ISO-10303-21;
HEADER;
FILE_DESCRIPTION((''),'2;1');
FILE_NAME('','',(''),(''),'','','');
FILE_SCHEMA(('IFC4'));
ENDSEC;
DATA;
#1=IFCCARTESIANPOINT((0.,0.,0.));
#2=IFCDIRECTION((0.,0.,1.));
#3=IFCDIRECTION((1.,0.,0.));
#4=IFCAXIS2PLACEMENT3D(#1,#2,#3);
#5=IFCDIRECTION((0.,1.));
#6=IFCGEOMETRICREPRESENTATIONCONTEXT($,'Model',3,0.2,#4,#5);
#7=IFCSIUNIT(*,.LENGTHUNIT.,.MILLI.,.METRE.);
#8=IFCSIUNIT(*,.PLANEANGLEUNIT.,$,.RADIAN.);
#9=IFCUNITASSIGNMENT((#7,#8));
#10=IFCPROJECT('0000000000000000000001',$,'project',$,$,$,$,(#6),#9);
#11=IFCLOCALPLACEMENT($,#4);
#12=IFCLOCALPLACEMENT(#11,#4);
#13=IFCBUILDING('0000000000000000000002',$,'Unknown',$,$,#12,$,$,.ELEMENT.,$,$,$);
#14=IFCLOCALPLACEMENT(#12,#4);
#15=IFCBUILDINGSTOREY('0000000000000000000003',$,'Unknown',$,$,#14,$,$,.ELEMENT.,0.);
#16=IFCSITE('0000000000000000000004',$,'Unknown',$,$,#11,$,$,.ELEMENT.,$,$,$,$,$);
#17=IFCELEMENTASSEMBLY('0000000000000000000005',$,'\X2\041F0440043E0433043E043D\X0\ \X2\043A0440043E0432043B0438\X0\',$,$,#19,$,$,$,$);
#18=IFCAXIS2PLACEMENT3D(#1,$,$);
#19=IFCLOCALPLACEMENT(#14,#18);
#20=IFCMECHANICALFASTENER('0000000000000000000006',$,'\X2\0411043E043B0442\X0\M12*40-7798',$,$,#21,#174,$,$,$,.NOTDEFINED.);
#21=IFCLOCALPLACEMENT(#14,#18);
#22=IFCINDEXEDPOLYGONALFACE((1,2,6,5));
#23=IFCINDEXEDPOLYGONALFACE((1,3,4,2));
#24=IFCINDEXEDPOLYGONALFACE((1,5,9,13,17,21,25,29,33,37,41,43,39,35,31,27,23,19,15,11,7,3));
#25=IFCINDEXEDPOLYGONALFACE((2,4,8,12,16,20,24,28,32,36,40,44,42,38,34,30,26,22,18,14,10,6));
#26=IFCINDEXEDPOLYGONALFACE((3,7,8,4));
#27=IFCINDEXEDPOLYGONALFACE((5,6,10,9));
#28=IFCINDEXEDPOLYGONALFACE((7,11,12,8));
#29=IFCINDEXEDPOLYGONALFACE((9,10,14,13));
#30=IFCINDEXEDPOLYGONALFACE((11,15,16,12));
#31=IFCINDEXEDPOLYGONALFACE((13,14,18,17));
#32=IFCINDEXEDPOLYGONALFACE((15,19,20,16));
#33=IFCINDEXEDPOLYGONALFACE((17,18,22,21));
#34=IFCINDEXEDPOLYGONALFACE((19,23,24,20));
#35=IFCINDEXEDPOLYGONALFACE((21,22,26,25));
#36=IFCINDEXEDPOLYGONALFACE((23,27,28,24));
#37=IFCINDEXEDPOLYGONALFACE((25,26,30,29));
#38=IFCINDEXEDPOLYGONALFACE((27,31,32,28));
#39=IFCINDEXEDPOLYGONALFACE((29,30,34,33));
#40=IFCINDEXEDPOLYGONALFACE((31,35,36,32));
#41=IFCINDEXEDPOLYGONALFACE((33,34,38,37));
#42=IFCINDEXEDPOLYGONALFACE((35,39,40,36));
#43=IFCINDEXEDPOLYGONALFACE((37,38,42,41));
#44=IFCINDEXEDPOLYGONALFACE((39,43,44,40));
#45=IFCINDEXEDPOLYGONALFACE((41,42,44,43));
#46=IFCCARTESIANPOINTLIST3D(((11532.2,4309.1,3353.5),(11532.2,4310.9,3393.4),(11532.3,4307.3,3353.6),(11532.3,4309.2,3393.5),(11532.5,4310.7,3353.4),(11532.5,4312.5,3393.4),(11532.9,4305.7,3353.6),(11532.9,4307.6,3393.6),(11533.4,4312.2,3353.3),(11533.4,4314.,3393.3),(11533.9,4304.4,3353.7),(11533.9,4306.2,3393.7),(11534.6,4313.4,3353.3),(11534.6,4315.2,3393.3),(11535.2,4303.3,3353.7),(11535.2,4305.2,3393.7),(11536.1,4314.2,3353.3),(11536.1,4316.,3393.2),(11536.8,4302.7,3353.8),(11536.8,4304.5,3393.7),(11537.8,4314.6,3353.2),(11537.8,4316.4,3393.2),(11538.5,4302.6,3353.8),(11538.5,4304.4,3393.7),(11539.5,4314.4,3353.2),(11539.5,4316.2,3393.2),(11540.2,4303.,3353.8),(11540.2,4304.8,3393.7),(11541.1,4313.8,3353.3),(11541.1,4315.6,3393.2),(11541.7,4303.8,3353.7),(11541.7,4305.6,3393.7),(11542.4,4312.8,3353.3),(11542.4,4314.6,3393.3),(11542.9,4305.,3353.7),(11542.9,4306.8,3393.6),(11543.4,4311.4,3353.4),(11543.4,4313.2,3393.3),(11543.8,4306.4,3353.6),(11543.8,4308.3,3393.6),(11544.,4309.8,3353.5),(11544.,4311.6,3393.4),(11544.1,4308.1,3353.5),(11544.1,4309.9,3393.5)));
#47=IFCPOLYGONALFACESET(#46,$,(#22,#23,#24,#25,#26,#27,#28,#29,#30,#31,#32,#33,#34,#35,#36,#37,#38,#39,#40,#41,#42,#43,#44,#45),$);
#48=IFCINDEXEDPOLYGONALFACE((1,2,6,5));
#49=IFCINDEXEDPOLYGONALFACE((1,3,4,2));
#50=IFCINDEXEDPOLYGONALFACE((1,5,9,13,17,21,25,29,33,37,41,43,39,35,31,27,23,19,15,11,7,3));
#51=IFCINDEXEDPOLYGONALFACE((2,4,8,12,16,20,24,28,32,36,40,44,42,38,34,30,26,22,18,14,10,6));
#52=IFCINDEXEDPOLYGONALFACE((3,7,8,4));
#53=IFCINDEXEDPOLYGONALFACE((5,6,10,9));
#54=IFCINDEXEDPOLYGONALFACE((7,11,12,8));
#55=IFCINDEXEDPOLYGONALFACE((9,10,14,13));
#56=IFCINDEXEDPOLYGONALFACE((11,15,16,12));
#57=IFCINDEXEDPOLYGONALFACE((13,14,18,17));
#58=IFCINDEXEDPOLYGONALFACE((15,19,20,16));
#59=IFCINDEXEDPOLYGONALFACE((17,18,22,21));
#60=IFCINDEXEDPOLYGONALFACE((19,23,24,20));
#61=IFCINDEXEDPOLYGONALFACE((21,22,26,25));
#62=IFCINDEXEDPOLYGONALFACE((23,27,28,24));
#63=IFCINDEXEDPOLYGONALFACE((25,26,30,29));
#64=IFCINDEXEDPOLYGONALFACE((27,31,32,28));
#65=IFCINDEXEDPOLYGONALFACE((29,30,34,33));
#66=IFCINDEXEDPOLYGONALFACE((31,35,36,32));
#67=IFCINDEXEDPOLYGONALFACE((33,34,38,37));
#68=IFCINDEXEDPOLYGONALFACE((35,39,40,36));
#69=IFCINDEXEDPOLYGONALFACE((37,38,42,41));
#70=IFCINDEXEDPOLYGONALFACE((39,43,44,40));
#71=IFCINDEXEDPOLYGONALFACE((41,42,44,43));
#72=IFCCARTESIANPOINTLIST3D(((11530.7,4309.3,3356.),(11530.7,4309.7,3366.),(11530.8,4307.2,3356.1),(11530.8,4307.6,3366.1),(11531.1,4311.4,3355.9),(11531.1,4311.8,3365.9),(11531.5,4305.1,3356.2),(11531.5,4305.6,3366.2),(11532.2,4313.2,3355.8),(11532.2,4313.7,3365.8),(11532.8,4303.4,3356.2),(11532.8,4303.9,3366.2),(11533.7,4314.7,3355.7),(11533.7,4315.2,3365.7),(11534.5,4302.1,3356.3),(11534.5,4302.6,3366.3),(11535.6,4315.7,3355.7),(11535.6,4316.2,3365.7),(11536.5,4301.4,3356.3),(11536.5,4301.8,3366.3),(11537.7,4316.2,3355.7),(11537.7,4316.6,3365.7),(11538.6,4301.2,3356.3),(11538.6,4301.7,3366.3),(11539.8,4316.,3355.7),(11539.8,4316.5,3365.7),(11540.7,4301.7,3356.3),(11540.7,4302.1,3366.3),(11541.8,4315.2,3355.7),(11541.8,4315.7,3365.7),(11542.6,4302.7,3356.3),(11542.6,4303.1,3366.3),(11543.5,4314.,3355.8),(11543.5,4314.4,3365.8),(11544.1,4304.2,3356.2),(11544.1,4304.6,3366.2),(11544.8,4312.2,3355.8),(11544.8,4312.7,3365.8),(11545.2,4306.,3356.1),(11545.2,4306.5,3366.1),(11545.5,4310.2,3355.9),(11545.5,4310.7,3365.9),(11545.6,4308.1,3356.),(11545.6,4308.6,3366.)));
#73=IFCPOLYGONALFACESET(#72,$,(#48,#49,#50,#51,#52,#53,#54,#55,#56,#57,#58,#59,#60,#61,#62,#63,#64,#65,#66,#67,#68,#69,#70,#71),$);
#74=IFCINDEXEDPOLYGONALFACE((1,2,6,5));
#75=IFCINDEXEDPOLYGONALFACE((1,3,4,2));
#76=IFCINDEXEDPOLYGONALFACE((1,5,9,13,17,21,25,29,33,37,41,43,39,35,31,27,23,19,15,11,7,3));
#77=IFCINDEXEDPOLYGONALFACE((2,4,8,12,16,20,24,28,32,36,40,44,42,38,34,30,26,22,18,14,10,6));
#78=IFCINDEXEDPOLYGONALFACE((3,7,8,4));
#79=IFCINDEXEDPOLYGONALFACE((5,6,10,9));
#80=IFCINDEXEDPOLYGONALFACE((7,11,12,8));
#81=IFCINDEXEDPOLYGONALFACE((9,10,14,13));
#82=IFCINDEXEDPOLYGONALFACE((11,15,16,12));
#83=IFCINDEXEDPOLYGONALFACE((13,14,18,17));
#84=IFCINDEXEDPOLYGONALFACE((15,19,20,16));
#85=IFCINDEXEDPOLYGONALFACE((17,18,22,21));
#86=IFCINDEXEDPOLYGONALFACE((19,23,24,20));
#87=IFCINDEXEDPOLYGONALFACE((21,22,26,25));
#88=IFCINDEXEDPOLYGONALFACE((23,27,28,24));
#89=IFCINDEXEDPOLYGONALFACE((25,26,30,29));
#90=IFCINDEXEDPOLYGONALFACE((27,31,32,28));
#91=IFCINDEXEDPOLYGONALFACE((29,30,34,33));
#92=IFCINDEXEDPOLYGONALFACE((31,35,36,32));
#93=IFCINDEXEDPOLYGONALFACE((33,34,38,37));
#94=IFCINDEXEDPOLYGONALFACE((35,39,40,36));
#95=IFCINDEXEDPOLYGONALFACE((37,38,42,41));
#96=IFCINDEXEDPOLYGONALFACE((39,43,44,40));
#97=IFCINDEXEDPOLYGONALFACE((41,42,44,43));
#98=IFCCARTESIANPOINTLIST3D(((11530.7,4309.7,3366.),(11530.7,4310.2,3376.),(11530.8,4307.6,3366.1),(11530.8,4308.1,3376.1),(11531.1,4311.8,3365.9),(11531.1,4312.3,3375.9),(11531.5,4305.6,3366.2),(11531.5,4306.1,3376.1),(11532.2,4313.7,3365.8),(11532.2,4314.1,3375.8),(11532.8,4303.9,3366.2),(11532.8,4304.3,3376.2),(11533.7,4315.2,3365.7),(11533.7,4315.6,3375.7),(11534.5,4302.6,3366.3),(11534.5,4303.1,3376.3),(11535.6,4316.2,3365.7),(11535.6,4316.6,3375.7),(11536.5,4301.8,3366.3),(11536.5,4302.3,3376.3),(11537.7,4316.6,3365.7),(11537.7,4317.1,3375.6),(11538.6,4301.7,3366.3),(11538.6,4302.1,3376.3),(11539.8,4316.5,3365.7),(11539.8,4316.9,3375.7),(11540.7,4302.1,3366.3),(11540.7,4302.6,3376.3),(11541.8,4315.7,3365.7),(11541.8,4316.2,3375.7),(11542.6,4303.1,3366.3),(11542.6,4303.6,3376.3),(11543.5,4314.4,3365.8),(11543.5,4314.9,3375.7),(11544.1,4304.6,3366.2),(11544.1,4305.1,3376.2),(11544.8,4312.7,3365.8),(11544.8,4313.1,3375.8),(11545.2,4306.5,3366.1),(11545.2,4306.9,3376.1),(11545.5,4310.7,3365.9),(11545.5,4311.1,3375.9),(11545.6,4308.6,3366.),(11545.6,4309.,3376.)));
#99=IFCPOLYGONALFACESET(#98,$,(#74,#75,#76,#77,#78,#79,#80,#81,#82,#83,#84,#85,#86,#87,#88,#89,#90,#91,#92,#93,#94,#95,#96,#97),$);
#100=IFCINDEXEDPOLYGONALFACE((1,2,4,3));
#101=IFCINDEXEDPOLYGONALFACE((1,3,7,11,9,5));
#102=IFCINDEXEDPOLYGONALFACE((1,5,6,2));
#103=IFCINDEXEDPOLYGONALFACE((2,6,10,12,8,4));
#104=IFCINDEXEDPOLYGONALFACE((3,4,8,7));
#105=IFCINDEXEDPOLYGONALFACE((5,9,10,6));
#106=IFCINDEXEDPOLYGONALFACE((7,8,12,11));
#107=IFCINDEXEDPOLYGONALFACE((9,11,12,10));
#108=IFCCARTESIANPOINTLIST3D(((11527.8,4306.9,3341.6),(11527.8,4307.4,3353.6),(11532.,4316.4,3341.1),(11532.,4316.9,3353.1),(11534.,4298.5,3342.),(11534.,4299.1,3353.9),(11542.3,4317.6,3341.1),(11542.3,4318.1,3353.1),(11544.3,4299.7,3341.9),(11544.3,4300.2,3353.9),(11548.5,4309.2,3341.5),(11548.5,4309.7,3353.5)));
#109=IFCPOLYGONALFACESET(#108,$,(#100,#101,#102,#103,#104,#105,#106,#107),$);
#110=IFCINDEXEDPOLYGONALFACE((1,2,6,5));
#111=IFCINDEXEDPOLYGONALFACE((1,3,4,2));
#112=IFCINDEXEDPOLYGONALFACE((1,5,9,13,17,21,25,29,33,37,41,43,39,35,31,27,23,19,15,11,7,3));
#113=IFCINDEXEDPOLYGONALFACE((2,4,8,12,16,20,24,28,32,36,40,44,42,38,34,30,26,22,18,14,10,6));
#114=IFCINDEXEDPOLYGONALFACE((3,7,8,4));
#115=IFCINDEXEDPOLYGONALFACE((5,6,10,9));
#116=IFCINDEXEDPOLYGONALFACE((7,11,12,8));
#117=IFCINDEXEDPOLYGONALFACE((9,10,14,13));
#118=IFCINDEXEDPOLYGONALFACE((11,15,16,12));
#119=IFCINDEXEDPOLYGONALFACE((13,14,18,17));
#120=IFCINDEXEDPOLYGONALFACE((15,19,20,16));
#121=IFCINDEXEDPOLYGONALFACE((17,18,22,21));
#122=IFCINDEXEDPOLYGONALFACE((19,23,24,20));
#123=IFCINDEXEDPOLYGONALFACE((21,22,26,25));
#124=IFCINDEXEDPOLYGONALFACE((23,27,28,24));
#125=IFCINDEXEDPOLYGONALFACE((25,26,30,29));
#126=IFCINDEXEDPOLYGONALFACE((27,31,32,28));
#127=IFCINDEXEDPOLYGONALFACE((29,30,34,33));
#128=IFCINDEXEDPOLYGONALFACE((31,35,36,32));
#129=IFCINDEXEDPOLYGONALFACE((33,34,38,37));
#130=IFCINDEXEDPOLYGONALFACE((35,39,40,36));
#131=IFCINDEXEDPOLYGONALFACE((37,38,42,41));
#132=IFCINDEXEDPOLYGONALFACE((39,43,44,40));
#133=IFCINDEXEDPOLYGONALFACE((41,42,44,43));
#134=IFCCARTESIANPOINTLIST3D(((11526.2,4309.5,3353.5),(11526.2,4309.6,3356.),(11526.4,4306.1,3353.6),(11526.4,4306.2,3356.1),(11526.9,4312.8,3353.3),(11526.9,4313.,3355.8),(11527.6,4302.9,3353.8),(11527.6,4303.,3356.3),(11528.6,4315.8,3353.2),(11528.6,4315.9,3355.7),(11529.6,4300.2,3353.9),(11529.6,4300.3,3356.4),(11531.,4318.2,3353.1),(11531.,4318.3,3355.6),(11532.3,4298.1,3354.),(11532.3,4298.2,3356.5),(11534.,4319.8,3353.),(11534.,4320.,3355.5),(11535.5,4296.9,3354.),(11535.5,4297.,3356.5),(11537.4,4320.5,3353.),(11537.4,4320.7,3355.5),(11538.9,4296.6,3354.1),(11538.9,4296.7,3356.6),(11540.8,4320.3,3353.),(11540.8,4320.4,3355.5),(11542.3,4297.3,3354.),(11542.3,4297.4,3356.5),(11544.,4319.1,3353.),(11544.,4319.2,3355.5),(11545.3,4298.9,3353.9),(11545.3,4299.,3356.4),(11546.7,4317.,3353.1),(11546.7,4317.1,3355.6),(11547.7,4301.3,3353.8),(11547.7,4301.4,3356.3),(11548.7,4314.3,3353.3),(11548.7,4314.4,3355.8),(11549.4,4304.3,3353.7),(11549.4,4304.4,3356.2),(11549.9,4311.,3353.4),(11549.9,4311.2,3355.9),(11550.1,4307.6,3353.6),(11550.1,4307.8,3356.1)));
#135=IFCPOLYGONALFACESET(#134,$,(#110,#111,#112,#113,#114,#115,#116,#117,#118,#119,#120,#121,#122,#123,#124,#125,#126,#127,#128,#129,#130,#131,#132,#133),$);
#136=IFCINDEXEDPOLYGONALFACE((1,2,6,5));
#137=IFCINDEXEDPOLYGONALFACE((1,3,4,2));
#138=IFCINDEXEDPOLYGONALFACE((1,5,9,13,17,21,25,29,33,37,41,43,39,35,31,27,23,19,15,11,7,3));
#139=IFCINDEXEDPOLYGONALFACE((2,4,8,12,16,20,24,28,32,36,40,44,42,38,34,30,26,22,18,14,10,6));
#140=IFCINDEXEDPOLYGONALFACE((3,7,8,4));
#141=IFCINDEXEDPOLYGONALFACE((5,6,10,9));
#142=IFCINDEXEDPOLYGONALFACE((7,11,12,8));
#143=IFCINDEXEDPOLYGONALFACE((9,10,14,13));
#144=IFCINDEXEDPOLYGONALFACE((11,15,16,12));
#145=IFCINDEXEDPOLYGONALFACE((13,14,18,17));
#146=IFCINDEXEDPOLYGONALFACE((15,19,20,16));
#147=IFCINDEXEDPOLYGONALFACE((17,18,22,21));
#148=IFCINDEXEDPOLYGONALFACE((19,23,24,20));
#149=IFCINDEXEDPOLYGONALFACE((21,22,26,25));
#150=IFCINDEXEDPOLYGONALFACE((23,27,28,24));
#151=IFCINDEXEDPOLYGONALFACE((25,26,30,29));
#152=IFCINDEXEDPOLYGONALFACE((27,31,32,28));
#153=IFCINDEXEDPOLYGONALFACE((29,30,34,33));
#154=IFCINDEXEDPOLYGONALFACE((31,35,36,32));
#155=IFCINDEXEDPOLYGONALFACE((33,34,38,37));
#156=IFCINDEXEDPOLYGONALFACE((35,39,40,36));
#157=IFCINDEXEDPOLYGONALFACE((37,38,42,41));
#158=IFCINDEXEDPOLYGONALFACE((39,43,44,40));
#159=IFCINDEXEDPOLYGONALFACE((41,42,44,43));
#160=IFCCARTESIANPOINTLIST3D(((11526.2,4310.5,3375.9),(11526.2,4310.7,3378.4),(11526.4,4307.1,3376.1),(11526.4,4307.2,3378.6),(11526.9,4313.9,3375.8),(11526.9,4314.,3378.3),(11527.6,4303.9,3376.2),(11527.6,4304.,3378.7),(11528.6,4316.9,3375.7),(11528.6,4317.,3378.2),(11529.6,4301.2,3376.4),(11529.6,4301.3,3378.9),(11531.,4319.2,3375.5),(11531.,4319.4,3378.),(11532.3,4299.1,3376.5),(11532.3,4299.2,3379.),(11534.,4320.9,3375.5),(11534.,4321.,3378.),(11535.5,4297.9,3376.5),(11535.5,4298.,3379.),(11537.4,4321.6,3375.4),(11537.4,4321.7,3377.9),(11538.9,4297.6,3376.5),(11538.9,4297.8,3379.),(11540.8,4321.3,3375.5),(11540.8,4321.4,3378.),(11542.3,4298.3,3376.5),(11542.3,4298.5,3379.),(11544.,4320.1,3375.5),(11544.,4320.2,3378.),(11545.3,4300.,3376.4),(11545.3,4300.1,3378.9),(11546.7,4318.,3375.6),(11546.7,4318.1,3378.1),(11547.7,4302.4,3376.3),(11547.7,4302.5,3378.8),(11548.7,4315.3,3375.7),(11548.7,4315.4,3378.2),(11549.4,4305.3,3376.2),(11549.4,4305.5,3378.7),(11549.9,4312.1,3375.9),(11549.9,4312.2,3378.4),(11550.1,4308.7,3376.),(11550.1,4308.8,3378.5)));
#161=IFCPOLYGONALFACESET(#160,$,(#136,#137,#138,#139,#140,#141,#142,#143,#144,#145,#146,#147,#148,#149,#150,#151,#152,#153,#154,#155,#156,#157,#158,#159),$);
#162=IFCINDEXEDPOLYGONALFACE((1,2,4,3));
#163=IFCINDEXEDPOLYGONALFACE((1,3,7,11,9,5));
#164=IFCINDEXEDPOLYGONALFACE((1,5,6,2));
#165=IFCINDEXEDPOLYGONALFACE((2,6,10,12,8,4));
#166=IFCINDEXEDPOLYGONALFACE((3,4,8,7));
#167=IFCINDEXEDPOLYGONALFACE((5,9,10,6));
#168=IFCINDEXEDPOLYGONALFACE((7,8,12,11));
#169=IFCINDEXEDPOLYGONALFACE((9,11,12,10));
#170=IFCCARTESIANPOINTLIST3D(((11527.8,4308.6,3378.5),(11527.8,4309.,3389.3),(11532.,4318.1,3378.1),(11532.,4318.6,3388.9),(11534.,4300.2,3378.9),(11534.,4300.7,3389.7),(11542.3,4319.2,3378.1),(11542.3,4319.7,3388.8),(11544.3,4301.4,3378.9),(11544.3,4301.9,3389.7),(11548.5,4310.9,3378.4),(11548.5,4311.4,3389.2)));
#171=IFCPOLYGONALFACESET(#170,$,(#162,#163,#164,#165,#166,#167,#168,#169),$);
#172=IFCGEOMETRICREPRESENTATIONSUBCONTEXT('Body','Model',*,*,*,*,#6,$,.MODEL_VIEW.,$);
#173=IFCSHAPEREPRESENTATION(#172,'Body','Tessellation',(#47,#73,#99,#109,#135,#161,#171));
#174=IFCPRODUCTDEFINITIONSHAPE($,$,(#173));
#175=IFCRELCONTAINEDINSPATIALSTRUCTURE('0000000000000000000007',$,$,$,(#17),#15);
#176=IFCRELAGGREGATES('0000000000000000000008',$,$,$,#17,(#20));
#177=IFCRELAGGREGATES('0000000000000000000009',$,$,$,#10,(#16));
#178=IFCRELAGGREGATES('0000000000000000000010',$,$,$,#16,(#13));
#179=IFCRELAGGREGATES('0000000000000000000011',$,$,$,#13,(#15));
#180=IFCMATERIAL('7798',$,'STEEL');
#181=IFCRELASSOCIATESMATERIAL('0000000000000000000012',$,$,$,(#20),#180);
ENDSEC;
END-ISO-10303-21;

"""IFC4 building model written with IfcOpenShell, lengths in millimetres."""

from ifc_helpers import new_model, si_unit, direction, frame, origin_with_axes, place, context, subcontext, project, spatial, line, arc, indexed_curve, outline, extrude, source, transform, mapped, material, element, aggregate, save


model = new_model("IFC4")

# Units and contexts
model_context = context("Model", 3, precision=0.2, world=origin_with_axes(), true_north=direction((0.0, 1.0)))
body_context = subcontext(model_context, "Body", "Model", "MODEL_VIEW")
ifc_project = project(units=[si_unit("LENGTHUNIT", "METRE", prefix="MILLI"), si_unit("PLANEANGLEUNIT", "RADIAN")], contexts=[model_context])

# Site, building, storey
site_placement = place(None, origin_with_axes())
site = spatial("IfcSite", under=ifc_project, at=site_placement, Name="Unknown", CompositionType="ELEMENT")
building_placement = place(site_placement, origin_with_axes())
building = spatial("IfcBuilding", under=site, at=building_placement, Name="Unknown", CompositionType="ELEMENT")
storey_placement = place(building_placement, origin_with_axes())
storey = spatial("IfcBuildingStorey", under=building, at=storey_placement, Name="Unknown", CompositionType="ELEMENT", Elevation=0.0)

# Element assembly
assembly_1_placement = place(storey_placement, frame((17395.0, 4207.1, 3365.6), z_axis=(0.0, 0.998969, -0.045408), x_axis=(-1.0, 0.0, 0.0)))
assembly_1 = element("IfcElementAssembly", 1, at=assembly_1_placement, inside=storey, Name="Прогон кровли")

# Mechanical fastener
ifc_material_1 = material(Name="7798", Category="STEEL")
shared_shape_1 = source(origin_with_axes(), body_context, "Body", "SweptSolid", [
    extrude(outline(indexed_curve([(6.0, 0.0), (0.0, 6.0), (-6.0, 0.0), (0.0, -6.0)], segments=[arc(1, 2, 3), arc(3, 4, 1)])), frame((0.0, 0.0, 2.5), z_axis=(0.0, 0.0, -1.0), x_axis=(0.0, 1.0, 0.0)), (0.0, 0.0, 1.0), 40.0),
    extrude(outline(indexed_curve([(7.5, 0.0), (0.0, 7.5), (-7.5, 0.0), (0.0, -7.5)], segments=[arc(1, 2, 3), arc(3, 4, 1)])), frame((0.0, 0.0, 0.0), z_axis=(0.0, 0.0, -1.0), x_axis=(0.0, 1.0, 0.0)), (0.0, 0.0, 1.0), 10.0),
    extrude(outline(indexed_curve([(7.5, 0.0), (0.0, 7.5), (-7.5, 0.0), (0.0, -7.5)], segments=[arc(1, 2, 3), arc(3, 4, 1)])), frame((0.0, 0.0, -10.0), z_axis=(0.0, 0.0, -1.0), x_axis=(0.0, 1.0, 0.0)), (0.0, 0.0, 1.0), 10.0),
    extrude(outline(indexed_curve([(10.4, 0.0), (5.2, 9.0), (-5.2, 9.0), (-10.4, 0.0), (-5.2, -9.0), (5.2, -9.0)], segments=[line(1, 2, 3, 4, 5, 6, 1)])), frame((0.0, 0.0, 14.5), z_axis=(0.0, 0.0, -1.0), x_axis=(0.0, 1.0, 0.0)), (0.0, 0.0, 1.0), 12.0),
    extrude(outline(indexed_curve([(12.0, 0.0), (0.0, 12.0), (-12.0, 0.0), (0.0, -12.0)], segments=[arc(1, 2, 3), arc(3, 4, 1)])), frame((0.0, 0.0, 2.5), z_axis=(0.0, 0.0, -1.0), x_axis=(0.0, 1.0, 0.0)), (0.0, 0.0, 1.0), 2.5),
    extrude(outline(indexed_curve([(12.0, 0.0), (0.0, 12.0), (-12.0, 0.0), (0.0, -12.0)], segments=[arc(1, 2, 3), arc(3, 4, 1)])), frame((0.0, 0.0, -20.0), z_axis=(0.0, 0.0, -1.0), x_axis=(0.0, 1.0, 0.0)), (0.0, 0.0, 1.0), 2.5),
    extrude(outline(indexed_curve([(10.4, 0.0), (5.2, 9.0), (-5.2, 9.0), (-10.4, 0.0), (-5.2, -9.0), (5.2, -9.0)], segments=[line(1, 2, 3, 4, 5, 6, 1)])), frame((0.0, 0.0, -22.5), z_axis=(0.0, 0.0, -1.0), x_axis=(0.0, 1.0, 0.0)), (0.0, 0.0, 1.0), 10.8),
])
mechanical_fastener_1_placement = place(assembly_1_placement, frame((5856.9, -5.0, 102.0), z_axis=(0.0, -1.0, 0.0), x_axis=(-0.804616, 0.0, 0.593795)))
mechanical_fastener_1 = element("IfcMechanicalFastener", 2, at=mechanical_fastener_1_placement, material=ifc_material_1, Name="БолтM12*40-7798", PredefinedType="NOTDEFINED", context=body_context, shape_type="MappedRepresentation", body=[
    mapped(shared_shape_1, transform((0.0, 0.0, 0.0))),
])
aggregate(assembly_1, [mechanical_fastener_1])

save(model, "model.ifc")
